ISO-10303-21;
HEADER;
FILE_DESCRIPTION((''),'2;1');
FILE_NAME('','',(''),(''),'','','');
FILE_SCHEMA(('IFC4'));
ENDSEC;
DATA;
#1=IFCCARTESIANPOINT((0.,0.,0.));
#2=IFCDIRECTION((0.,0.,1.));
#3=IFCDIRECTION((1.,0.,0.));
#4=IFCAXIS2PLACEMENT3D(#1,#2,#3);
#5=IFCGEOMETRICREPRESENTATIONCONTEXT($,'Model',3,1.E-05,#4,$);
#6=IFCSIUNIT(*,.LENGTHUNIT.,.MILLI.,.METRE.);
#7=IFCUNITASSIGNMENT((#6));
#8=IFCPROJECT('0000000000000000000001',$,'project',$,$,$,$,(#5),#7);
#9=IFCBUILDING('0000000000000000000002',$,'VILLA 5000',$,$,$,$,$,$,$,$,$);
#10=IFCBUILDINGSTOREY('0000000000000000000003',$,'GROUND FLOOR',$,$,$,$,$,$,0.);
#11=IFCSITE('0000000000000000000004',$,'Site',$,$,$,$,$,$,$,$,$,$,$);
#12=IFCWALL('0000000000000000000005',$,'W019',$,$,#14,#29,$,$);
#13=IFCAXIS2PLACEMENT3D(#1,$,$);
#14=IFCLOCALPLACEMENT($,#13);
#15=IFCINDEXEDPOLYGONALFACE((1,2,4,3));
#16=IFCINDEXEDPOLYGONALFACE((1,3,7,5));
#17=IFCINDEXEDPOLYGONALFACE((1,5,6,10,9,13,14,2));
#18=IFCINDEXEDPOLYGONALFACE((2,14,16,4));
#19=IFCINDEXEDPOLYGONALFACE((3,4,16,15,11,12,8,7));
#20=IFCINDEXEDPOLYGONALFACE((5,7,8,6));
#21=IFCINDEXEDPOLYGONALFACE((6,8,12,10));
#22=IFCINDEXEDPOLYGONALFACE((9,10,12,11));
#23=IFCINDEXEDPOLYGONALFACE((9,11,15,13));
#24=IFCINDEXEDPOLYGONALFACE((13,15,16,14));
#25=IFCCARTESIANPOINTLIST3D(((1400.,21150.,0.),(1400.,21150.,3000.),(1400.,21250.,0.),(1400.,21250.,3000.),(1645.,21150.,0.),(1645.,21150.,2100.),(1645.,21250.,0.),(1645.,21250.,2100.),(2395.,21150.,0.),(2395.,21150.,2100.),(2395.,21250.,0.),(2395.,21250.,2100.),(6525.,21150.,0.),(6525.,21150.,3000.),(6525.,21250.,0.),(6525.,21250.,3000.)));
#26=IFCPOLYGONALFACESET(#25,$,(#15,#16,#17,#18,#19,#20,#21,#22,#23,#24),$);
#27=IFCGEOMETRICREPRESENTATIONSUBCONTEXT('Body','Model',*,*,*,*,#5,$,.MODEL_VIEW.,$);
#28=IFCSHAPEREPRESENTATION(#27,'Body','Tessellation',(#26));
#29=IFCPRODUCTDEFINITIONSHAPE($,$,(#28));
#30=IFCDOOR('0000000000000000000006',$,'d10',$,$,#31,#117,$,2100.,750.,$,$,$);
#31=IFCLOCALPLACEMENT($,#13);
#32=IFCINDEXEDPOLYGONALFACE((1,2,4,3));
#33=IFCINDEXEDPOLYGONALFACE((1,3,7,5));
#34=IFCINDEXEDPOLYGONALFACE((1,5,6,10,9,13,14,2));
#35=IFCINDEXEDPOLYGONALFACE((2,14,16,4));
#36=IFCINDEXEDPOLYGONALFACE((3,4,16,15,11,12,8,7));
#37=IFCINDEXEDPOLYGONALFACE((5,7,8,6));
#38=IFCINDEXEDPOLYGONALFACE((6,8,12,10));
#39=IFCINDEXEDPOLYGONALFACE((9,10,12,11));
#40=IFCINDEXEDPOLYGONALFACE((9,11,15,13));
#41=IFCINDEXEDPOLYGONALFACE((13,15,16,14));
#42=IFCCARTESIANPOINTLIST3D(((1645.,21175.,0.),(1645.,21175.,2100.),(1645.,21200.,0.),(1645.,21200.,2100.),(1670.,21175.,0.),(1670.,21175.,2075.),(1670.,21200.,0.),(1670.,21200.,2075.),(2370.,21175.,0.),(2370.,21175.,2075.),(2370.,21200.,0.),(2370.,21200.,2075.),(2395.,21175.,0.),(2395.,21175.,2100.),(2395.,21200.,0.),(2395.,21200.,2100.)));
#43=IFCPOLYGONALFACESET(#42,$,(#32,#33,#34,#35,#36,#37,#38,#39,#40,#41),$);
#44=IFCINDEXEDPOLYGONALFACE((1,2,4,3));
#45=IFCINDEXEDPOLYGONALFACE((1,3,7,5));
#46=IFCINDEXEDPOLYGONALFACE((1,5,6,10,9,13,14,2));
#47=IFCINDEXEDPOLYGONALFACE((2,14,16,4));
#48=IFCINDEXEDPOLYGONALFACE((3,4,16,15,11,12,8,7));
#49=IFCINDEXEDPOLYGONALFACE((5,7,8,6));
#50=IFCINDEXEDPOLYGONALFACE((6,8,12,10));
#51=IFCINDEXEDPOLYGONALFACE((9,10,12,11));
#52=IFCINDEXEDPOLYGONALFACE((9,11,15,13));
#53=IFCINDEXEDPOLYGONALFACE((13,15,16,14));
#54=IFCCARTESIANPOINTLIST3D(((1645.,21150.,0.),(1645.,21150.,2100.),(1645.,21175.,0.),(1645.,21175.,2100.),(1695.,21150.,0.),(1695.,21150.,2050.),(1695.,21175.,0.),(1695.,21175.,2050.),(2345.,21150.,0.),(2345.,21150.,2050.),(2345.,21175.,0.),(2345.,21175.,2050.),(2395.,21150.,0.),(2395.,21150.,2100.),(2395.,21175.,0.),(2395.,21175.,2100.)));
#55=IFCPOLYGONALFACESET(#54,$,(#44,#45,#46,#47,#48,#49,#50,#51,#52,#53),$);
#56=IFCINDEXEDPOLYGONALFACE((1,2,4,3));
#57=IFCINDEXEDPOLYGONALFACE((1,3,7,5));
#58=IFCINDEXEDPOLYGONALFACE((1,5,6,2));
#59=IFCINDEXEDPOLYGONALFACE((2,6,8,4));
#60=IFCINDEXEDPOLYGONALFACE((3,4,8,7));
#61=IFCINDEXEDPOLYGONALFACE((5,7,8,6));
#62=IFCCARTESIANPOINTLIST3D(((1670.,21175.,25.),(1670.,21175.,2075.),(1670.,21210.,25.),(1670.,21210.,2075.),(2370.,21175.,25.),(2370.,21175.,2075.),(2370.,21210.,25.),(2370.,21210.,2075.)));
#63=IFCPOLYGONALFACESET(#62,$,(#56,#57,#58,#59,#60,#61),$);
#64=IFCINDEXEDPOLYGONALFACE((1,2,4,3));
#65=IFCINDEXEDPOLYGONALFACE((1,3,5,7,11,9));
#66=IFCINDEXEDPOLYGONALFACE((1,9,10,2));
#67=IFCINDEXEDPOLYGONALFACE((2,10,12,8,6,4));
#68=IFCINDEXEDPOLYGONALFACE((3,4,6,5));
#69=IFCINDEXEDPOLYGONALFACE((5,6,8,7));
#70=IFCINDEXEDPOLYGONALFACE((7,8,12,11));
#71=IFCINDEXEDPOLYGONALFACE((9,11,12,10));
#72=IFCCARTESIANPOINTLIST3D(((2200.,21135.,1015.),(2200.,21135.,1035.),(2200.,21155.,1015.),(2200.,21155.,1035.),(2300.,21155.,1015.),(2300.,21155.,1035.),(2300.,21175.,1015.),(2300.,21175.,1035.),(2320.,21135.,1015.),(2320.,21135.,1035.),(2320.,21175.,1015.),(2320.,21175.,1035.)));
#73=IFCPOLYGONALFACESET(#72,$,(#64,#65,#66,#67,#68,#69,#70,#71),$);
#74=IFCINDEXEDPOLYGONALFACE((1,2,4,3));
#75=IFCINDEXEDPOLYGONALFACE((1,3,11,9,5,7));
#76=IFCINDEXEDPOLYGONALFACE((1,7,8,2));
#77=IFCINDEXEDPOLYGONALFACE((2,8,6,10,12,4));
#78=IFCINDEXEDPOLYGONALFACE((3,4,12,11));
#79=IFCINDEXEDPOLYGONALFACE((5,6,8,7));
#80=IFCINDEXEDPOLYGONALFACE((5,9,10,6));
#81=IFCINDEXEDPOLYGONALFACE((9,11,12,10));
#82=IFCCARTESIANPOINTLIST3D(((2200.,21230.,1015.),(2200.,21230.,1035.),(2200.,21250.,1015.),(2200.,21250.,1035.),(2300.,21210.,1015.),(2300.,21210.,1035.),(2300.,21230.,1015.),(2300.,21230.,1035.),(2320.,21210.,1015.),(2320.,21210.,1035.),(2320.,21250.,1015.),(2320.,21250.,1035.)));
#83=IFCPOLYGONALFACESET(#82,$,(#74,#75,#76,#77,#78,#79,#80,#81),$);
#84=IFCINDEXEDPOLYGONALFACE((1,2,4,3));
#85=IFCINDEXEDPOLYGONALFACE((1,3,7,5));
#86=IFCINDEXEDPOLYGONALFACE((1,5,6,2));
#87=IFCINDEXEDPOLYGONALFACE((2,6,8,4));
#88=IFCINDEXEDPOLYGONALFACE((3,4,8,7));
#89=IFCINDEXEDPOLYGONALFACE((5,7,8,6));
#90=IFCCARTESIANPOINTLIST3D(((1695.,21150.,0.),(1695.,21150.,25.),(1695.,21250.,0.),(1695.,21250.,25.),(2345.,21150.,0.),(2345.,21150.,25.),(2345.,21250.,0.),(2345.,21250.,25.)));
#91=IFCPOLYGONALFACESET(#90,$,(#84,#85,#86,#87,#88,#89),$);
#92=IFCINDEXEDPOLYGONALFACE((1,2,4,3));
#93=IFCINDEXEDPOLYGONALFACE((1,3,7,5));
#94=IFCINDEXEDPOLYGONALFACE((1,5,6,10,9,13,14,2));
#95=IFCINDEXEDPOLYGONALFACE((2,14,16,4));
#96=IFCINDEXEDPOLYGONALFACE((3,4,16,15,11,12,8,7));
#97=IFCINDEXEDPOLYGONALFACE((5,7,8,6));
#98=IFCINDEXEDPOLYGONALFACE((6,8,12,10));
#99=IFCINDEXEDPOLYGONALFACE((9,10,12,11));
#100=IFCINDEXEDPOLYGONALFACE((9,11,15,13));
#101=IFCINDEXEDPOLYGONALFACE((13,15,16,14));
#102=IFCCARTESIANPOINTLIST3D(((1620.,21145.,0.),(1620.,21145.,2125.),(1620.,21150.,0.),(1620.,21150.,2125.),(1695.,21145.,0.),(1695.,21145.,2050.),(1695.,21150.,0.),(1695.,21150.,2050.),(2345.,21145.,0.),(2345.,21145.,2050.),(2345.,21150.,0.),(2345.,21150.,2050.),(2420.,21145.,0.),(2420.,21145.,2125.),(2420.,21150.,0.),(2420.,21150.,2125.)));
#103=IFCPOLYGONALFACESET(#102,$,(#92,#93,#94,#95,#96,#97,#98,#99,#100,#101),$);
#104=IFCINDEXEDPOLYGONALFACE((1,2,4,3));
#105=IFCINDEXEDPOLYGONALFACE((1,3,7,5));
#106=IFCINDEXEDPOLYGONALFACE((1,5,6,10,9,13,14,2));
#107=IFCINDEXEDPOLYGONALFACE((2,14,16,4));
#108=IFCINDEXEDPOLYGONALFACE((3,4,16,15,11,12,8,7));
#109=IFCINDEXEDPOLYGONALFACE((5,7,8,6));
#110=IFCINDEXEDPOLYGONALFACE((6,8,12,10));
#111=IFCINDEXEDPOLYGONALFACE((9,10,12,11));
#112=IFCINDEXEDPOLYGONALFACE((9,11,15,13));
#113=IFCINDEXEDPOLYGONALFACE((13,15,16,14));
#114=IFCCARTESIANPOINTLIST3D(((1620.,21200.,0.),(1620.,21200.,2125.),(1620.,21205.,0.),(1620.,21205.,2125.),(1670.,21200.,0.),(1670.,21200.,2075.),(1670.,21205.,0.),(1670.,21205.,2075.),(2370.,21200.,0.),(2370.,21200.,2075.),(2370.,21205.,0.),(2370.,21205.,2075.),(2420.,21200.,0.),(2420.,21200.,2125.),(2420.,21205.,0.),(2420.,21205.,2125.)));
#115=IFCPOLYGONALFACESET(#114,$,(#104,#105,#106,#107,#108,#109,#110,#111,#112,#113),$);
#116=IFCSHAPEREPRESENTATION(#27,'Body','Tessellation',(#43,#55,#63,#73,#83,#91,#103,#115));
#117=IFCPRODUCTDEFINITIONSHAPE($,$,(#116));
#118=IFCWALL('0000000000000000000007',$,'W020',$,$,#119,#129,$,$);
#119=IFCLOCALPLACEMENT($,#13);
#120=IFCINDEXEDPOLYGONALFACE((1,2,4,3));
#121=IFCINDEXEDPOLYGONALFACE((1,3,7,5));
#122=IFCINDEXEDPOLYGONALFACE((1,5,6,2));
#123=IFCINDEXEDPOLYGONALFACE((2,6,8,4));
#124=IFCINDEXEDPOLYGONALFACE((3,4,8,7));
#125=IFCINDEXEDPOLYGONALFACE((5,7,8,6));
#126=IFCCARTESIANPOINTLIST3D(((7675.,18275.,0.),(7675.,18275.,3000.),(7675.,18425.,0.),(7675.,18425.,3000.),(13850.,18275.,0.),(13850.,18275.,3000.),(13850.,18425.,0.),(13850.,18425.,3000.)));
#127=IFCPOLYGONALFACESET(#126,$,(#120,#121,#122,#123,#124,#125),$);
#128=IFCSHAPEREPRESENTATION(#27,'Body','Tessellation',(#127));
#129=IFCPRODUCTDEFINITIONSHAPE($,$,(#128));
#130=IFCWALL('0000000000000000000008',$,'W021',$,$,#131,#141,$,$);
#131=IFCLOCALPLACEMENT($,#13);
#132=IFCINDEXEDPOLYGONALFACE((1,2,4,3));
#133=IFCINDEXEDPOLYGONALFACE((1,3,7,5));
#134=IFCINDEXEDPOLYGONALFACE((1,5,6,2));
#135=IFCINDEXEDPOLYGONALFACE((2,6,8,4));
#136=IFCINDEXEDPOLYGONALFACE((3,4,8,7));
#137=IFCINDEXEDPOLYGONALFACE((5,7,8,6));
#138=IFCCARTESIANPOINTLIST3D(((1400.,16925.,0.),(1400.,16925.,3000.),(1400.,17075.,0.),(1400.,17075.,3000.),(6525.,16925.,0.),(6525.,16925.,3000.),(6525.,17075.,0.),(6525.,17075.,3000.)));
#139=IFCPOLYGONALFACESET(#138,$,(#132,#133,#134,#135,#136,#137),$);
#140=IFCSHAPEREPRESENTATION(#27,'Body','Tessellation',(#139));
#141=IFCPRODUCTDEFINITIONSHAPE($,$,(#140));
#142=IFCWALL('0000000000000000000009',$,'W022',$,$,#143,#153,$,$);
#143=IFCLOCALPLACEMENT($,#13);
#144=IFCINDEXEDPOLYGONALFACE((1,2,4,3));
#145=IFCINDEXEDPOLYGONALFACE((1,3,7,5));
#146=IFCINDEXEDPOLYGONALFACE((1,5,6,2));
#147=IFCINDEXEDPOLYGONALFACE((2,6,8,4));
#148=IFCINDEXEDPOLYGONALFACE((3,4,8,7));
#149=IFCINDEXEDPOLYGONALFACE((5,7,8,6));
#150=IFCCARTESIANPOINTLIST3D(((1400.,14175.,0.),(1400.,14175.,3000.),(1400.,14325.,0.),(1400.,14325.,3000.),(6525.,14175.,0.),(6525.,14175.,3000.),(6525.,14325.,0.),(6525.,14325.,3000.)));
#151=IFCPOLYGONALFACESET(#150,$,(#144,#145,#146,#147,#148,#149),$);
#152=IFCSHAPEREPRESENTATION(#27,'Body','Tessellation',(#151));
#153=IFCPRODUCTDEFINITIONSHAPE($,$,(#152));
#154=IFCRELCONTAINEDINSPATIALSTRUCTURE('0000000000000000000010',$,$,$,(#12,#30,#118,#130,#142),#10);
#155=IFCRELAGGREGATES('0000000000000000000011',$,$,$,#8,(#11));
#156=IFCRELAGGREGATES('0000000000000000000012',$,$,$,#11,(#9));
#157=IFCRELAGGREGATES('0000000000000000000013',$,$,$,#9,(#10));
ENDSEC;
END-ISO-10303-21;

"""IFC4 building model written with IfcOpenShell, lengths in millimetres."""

from ifc_helpers import new_model, si_unit, frame, origin_with_axes, place, context, subcontext, project, spatial, line, indexed_curve, outline, extrude, element, fill, save


model = new_model("IFC4")

# Units and contexts
model_context = context("Model", 3, precision=1e-05, world=origin_with_axes())
body_context = subcontext(model_context, "Body", "Model", "MODEL_VIEW")
ifc_project = project(units=[si_unit("LENGTHUNIT", "METRE", prefix="MILLI")], contexts=[model_context])

# Site, building, storey
site = spatial("IfcSite", under=ifc_project, Name="Site")
building = spatial("IfcBuilding", under=site, Name="VILLA 5000")
storey = spatial("IfcBuildingStorey", under=building, Name="GROUND FLOOR", Elevation=0.0)

# Wall, opening, door
wall_1_placement = place(None, frame((1400.0, 21200.0, 0.0), z_axis=(0.0, 0.0, 1.0), x_axis=(1.0, 0.0, 0.0)))
wall_1 = element("IfcWall", 1, at=wall_1_placement, inside=storey, Name="W019", context=body_context, shape_type="SweptSolid", body=[
    extrude(outline(indexed_curve([(0.0, 0.0), (0.0, 100.0), (5125.0, 100.0), (5125.0, 0.0), (0.0, 0.0)], self_intersect=False)), frame((0.0, -50.0, 0.0), z_axis=(0.0, 0.0, 1.0), x_axis=(1.0, 0.0, 0.0)), (0.0, 0.0, 1.0), 3000.0),
])
opening_1_placement = place(wall_1_placement, frame((245.0, 0.0, 0.0), z_axis=(0.0, 0.0, 1.0), x_axis=(1.0, 0.0, 0.0)))
opening_1 = element("IfcOpeningElement", 2, at=opening_1_placement, cuts=wall_1, context=body_context, shape_type="SweptSolid", body=[
    extrude(outline(indexed_curve([(0.0, 0.0), (0.0, 200.0), (750.0, 200.0), (750.0, 0.0), (0.0, 0.0)], self_intersect=False)), frame((0.0, -100.0, 0.0), z_axis=(0.0, 0.0, 1.0), x_axis=(1.0, 0.0, 0.0)), (0.0, 0.0, 1.0), 2100.0),
])
door_1_placement = place(None, frame((1645.0, 21150.0, 0.0), z_axis=(0.0, 0.0, 1.0), x_axis=(1.0, 0.0, 0.0)))
door_1 = element("IfcDoor", 3, at=door_1_placement, inside=storey, Name="d10", OverallHeight=2100.0, OverallWidth=750.0, context=body_context, shape_type="SweptSolid", body=[
    extrude(outline(indexed_curve([(0.0, 0.0), (0.0, 2100.0), (750.0, 2100.0), (750.0, 0.0), (725.0, 0.0), (725.0, 2075.0), (25.0, 2075.0), (25.0, 0.0)], segments=[line(1, 2, 3, 4, 5, 6, 7, 8, 1)])), frame((0.0, 25.0, 0.0), z_axis=(0.0, -1.0, 0.0), x_axis=(1.0, 0.0, 0.0)), (0.0, 0.0, -1.0), 25.0),
    extrude(outline(indexed_curve([(0.0, 0.0), (0.0, 2100.0), (750.0, 2100.0), (750.0, 0.0), (700.0, 0.0), (700.0, 2050.0), (50.0, 2050.0), (50.0, 0.0)], segments=[line(1, 2, 3, 4, 5, 6, 7, 8, 1)])), frame((0.0, 0.0, 0.0), z_axis=(0.0, -1.0, 0.0), x_axis=(1.0, 0.0, 0.0)), (0.0, 0.0, -1.0), 25.0),
    extrude(outline(indexed_curve([(0.0, 0.0), (700.0, 0.0), (700.0, 35.0), (0.0, 35.0)], segments=[line(1, 2, 3, 4, 1)])), frame((25.0, 25.0, 25.0), z_axis=(0.0, 0.0, 1.0), x_axis=(1.0, 0.0, 0.0)), (0.0, 0.0, 1.0), 2050.0),
    extrude(outline(indexed_curve([(0.0, 0.0), (0.0, -40.0), (-120.0, -40.0), (-120.0, -20.0), (-20.0, -20.0), (-20.0, 0.0)], segments=[line(1, 2, 3, 4, 5, 6, 1)])), frame((675.0, 25.0, 1015.0), z_axis=(0.0, 0.0, 1.0), x_axis=(1.0, 0.0, 0.0)), (0.0, 0.0, 1.0), 20.0),
    extrude(outline(indexed_curve([(0.0, 0.0), (0.0, 40.0), (-120.0, 40.0), (-120.0, 20.0), (-20.0, 20.0), (-20.0, 0.0)], segments=[line(1, 2, 3, 4, 5, 6, 1)])), frame((675.0, 60.0, 1015.0), z_axis=(0.0, 0.0, 1.0), x_axis=(1.0, 0.0, 0.0)), (0.0, 0.0, 1.0), 20.0),
    extrude(outline(indexed_curve([(0.0, 0.0), (650.0, 0.0), (650.0, 100.0), (0.0, 100.0)], segments=[line(1, 2, 3, 4, 1)])), frame((50.0, 0.0, 0.0), z_axis=(0.0, 0.0, 1.0), x_axis=(1.0, 0.0, 0.0)), (0.0, 0.0, 1.0), 25.0),
    extrude(outline(indexed_curve([(0.0, 0.0), (0.0, 2125.0), (800.0, 2125.0), (800.0, 0.0), (725.0, 0.0), (725.0, 2050.0), (75.0, 2050.0), (75.0, 0.0)], segments=[line(1, 2, 3, 4, 5, 6, 7, 8, 1)])), frame((-25.0, -5.0, 0.0), z_axis=(0.0, -1.0, 0.0), x_axis=(1.0, 0.0, 0.0)), (0.0, 0.0, -1.0), 5.0),
    extrude(outline(indexed_curve([(0.0, 0.0), (0.0, 2125.0), (800.0, 2125.0), (800.0, 0.0), (750.0, 0.0), (750.0, 2075.0), (50.0, 2075.0), (50.0, 0.0)], segments=[line(1, 2, 3, 4, 5, 6, 7, 8, 1)])), frame((-25.0, 50.0, 0.0), z_axis=(0.0, -1.0, 0.0), x_axis=(1.0, 0.0, 0.0)), (0.0, 0.0, -1.0), 5.0),
])
fill(opening_1, door_1)

# Walls
wall_2_placement = place(None, frame((7675.0, 18350.0, 0.0), z_axis=(0.0, 0.0, 1.0), x_axis=(1.0, 0.0, 0.0)))
element("IfcWall", 4, at=wall_2_placement, inside=storey, Name="W020", context=body_context, shape_type="SweptSolid", body=[
    extrude(outline(indexed_curve([(0.0, 0.0), (0.0, 150.0), (6175.0, 150.0), (6175.0, 0.0), (0.0, 0.0)], self_intersect=False)), frame((0.0, -75.0, 0.0), z_axis=(0.0, 0.0, 1.0), x_axis=(1.0, 0.0, 0.0)), (0.0, 0.0, 1.0), 3000.0),
])
for number, where, z_axis, x_axis, name in (
    (5, (1400.0, 17000.0, 0.0), (0.0, 0.0, 1.0), (1.0, 0.0, 0.0), "W021"),
    (6, (1400.0, 14250.0, 0.0), (0.0, 0.0, 1.0), (1.0, 0.0, 0.0), "W022"),
):
    element("IfcWall", number, at=place(None, frame(where, z_axis=z_axis, x_axis=x_axis)), inside=storey, Name=name, context=body_context, shape_type="SweptSolid", body=[
        extrude(outline(indexed_curve([(0.0, 0.0), (0.0, 150.0), (5125.0, 150.0), (5125.0, 0.0), (0.0, 0.0)], self_intersect=False)), frame((0.0, -75.0, 0.0), z_axis=(0.0, 0.0, 1.0), x_axis=(1.0, 0.0, 0.0)), (0.0, 0.0, 1.0), 3000.0),
    ])

save(model, "model.ifc")
